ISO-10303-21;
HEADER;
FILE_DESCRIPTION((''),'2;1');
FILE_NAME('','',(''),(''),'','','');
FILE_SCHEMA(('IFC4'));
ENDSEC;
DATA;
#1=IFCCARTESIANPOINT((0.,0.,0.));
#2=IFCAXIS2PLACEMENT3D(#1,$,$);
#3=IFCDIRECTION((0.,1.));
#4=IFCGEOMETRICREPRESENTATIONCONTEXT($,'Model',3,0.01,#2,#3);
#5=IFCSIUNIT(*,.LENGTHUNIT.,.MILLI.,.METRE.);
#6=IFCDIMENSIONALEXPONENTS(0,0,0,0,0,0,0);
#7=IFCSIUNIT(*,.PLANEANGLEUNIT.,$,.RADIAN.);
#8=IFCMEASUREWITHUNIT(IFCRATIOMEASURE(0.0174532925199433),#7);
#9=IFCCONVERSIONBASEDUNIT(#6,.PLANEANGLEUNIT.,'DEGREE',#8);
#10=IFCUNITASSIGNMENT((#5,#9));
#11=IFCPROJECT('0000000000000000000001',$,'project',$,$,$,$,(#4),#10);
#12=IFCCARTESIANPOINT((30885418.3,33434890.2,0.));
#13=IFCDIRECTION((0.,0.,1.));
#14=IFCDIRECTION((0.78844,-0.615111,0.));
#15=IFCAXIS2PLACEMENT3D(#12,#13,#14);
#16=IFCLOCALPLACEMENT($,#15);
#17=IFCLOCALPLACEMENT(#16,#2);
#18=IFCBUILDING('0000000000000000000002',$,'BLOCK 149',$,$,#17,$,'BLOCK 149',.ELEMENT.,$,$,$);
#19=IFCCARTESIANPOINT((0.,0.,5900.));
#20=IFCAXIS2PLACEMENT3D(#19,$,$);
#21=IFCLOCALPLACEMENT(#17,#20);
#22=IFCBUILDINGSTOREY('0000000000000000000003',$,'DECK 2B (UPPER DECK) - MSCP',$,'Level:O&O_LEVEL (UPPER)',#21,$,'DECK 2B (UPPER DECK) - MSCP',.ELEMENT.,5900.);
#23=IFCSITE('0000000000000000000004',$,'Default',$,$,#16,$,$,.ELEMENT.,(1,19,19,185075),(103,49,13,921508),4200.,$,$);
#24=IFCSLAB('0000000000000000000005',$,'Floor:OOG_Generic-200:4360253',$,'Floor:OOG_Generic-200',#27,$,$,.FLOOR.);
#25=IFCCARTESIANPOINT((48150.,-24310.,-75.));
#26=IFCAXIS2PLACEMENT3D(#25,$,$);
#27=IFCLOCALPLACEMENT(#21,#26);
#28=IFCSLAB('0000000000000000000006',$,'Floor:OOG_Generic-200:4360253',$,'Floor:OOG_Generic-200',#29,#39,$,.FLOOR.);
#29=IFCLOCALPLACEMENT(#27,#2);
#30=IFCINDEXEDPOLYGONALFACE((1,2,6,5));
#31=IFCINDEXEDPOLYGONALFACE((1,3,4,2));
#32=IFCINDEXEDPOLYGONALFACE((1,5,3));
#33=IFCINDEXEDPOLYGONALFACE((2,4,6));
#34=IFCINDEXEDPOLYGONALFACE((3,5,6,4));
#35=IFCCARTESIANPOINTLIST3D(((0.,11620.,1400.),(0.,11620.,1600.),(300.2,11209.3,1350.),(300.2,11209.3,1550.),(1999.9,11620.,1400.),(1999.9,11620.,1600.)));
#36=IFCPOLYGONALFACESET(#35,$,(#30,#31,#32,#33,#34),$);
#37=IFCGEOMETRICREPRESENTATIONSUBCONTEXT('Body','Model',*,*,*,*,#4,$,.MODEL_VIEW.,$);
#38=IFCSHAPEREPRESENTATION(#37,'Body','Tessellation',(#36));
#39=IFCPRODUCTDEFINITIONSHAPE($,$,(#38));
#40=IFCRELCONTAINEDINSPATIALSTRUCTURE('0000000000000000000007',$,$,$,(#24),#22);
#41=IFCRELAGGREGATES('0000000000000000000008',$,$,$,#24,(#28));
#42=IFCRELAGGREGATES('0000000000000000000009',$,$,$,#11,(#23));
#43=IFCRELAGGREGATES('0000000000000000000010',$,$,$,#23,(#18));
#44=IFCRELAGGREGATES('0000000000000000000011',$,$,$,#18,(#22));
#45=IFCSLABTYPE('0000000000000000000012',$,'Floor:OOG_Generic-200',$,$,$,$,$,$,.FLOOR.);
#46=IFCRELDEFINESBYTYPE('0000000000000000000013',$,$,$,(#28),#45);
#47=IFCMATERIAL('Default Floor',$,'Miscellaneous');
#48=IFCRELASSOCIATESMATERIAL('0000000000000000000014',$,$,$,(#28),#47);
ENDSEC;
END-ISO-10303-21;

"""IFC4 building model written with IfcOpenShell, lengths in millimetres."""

from ifc_helpers import new_model, entity, si_unit, converted_unit, direction, frame, origin, place, context, subcontext, project, spatial, indexed_curve, outline, extrude, material, type_object, element, aggregate, save


model = new_model("IFC4")

# Units and contexts
model_context = context("Model", 3, precision=0.01, world=origin(), true_north=direction((0.0, 1.0)))
body_context = subcontext(model_context, "Body", "Model", "MODEL_VIEW")
ifc_project = project(units=[si_unit("LENGTHUNIT", "METRE", prefix="MILLI"), converted_unit("PLANEANGLEUNIT", "DEGREE", entity("IfcRatioMeasure", 0.0174532925199433), si_unit("PLANEANGLEUNIT", "RADIAN"), dimensions=[0, 0, 0, 0, 0, 0, 0])], contexts=[model_context])

# Site, building, storey
site_placement = place(None, frame((30885418.3, 33434890.2, 0.0), z_axis=(0.0, 0.0, 1.0), x_axis=(0.78844, -0.615111, 0.0)))
site = spatial("IfcSite", under=ifc_project, at=site_placement, Name="Default", CompositionType="ELEMENT", RefLatitude=(1, 19, 19, 185075), RefLongitude=(103, 49, 13, 921508), RefElevation=4200.0)
building_placement = place(site_placement, origin())
building = spatial("IfcBuilding", under=site, at=building_placement, Name="BLOCK 149", LongName="BLOCK 149", CompositionType="ELEMENT")
storey_placement = place(building_placement, frame((0.0, 0.0, 5900.0)))
storey = spatial("IfcBuildingStorey", under=building, at=storey_placement, Name="DECK 2B (UPPER DECK) - MSCP", ObjectType="Level:O&O_LEVEL (UPPER)", LongName="DECK 2B (UPPER DECK) - MSCP", CompositionType="ELEMENT", Elevation=5900.0)

# Slabs
slab_1_placement = place(storey_placement, frame((48150.0, -24310.0, -75.0)))
slab_1 = element("IfcSlab", 1, at=slab_1_placement, inside=storey, Name="Floor:OOG_Generic-200:4360253", ObjectType="Floor:OOG_Generic-200", PredefinedType="FLOOR")
ifc_material_1 = material(Name="Default Floor", Category="Miscellaneous")
slab_type_1 = type_object("IfcSlabType", Name="Floor:OOG_Generic-200", PredefinedType="FLOOR")
slab_2_placement = place(slab_1_placement, origin())
slab_2 = element("IfcSlab", 2, at=slab_2_placement, type_object=slab_type_1, material=ifc_material_1, Name="Floor:OOG_Generic-200:4360253", ObjectType="Floor:OOG_Generic-200", PredefinedType="FLOOR", context=body_context, shape_type="SweptSolid", body=[
    extrude(outline(indexed_curve([(999.9, 0.0), (-999.9, 0.0), (-699.8, -413.8), (999.9, 0.0)], self_intersect=False)), frame((1000.0, 11620.0, 1600.0), z_axis=(0.0, -0.120838, 0.992672), x_axis=(1.0, 0.0, 0.0)), (0.0, -0.120838, -0.992672), 200.0),
])
aggregate(slab_1, [slab_2])

save(model, "model.ifc")
